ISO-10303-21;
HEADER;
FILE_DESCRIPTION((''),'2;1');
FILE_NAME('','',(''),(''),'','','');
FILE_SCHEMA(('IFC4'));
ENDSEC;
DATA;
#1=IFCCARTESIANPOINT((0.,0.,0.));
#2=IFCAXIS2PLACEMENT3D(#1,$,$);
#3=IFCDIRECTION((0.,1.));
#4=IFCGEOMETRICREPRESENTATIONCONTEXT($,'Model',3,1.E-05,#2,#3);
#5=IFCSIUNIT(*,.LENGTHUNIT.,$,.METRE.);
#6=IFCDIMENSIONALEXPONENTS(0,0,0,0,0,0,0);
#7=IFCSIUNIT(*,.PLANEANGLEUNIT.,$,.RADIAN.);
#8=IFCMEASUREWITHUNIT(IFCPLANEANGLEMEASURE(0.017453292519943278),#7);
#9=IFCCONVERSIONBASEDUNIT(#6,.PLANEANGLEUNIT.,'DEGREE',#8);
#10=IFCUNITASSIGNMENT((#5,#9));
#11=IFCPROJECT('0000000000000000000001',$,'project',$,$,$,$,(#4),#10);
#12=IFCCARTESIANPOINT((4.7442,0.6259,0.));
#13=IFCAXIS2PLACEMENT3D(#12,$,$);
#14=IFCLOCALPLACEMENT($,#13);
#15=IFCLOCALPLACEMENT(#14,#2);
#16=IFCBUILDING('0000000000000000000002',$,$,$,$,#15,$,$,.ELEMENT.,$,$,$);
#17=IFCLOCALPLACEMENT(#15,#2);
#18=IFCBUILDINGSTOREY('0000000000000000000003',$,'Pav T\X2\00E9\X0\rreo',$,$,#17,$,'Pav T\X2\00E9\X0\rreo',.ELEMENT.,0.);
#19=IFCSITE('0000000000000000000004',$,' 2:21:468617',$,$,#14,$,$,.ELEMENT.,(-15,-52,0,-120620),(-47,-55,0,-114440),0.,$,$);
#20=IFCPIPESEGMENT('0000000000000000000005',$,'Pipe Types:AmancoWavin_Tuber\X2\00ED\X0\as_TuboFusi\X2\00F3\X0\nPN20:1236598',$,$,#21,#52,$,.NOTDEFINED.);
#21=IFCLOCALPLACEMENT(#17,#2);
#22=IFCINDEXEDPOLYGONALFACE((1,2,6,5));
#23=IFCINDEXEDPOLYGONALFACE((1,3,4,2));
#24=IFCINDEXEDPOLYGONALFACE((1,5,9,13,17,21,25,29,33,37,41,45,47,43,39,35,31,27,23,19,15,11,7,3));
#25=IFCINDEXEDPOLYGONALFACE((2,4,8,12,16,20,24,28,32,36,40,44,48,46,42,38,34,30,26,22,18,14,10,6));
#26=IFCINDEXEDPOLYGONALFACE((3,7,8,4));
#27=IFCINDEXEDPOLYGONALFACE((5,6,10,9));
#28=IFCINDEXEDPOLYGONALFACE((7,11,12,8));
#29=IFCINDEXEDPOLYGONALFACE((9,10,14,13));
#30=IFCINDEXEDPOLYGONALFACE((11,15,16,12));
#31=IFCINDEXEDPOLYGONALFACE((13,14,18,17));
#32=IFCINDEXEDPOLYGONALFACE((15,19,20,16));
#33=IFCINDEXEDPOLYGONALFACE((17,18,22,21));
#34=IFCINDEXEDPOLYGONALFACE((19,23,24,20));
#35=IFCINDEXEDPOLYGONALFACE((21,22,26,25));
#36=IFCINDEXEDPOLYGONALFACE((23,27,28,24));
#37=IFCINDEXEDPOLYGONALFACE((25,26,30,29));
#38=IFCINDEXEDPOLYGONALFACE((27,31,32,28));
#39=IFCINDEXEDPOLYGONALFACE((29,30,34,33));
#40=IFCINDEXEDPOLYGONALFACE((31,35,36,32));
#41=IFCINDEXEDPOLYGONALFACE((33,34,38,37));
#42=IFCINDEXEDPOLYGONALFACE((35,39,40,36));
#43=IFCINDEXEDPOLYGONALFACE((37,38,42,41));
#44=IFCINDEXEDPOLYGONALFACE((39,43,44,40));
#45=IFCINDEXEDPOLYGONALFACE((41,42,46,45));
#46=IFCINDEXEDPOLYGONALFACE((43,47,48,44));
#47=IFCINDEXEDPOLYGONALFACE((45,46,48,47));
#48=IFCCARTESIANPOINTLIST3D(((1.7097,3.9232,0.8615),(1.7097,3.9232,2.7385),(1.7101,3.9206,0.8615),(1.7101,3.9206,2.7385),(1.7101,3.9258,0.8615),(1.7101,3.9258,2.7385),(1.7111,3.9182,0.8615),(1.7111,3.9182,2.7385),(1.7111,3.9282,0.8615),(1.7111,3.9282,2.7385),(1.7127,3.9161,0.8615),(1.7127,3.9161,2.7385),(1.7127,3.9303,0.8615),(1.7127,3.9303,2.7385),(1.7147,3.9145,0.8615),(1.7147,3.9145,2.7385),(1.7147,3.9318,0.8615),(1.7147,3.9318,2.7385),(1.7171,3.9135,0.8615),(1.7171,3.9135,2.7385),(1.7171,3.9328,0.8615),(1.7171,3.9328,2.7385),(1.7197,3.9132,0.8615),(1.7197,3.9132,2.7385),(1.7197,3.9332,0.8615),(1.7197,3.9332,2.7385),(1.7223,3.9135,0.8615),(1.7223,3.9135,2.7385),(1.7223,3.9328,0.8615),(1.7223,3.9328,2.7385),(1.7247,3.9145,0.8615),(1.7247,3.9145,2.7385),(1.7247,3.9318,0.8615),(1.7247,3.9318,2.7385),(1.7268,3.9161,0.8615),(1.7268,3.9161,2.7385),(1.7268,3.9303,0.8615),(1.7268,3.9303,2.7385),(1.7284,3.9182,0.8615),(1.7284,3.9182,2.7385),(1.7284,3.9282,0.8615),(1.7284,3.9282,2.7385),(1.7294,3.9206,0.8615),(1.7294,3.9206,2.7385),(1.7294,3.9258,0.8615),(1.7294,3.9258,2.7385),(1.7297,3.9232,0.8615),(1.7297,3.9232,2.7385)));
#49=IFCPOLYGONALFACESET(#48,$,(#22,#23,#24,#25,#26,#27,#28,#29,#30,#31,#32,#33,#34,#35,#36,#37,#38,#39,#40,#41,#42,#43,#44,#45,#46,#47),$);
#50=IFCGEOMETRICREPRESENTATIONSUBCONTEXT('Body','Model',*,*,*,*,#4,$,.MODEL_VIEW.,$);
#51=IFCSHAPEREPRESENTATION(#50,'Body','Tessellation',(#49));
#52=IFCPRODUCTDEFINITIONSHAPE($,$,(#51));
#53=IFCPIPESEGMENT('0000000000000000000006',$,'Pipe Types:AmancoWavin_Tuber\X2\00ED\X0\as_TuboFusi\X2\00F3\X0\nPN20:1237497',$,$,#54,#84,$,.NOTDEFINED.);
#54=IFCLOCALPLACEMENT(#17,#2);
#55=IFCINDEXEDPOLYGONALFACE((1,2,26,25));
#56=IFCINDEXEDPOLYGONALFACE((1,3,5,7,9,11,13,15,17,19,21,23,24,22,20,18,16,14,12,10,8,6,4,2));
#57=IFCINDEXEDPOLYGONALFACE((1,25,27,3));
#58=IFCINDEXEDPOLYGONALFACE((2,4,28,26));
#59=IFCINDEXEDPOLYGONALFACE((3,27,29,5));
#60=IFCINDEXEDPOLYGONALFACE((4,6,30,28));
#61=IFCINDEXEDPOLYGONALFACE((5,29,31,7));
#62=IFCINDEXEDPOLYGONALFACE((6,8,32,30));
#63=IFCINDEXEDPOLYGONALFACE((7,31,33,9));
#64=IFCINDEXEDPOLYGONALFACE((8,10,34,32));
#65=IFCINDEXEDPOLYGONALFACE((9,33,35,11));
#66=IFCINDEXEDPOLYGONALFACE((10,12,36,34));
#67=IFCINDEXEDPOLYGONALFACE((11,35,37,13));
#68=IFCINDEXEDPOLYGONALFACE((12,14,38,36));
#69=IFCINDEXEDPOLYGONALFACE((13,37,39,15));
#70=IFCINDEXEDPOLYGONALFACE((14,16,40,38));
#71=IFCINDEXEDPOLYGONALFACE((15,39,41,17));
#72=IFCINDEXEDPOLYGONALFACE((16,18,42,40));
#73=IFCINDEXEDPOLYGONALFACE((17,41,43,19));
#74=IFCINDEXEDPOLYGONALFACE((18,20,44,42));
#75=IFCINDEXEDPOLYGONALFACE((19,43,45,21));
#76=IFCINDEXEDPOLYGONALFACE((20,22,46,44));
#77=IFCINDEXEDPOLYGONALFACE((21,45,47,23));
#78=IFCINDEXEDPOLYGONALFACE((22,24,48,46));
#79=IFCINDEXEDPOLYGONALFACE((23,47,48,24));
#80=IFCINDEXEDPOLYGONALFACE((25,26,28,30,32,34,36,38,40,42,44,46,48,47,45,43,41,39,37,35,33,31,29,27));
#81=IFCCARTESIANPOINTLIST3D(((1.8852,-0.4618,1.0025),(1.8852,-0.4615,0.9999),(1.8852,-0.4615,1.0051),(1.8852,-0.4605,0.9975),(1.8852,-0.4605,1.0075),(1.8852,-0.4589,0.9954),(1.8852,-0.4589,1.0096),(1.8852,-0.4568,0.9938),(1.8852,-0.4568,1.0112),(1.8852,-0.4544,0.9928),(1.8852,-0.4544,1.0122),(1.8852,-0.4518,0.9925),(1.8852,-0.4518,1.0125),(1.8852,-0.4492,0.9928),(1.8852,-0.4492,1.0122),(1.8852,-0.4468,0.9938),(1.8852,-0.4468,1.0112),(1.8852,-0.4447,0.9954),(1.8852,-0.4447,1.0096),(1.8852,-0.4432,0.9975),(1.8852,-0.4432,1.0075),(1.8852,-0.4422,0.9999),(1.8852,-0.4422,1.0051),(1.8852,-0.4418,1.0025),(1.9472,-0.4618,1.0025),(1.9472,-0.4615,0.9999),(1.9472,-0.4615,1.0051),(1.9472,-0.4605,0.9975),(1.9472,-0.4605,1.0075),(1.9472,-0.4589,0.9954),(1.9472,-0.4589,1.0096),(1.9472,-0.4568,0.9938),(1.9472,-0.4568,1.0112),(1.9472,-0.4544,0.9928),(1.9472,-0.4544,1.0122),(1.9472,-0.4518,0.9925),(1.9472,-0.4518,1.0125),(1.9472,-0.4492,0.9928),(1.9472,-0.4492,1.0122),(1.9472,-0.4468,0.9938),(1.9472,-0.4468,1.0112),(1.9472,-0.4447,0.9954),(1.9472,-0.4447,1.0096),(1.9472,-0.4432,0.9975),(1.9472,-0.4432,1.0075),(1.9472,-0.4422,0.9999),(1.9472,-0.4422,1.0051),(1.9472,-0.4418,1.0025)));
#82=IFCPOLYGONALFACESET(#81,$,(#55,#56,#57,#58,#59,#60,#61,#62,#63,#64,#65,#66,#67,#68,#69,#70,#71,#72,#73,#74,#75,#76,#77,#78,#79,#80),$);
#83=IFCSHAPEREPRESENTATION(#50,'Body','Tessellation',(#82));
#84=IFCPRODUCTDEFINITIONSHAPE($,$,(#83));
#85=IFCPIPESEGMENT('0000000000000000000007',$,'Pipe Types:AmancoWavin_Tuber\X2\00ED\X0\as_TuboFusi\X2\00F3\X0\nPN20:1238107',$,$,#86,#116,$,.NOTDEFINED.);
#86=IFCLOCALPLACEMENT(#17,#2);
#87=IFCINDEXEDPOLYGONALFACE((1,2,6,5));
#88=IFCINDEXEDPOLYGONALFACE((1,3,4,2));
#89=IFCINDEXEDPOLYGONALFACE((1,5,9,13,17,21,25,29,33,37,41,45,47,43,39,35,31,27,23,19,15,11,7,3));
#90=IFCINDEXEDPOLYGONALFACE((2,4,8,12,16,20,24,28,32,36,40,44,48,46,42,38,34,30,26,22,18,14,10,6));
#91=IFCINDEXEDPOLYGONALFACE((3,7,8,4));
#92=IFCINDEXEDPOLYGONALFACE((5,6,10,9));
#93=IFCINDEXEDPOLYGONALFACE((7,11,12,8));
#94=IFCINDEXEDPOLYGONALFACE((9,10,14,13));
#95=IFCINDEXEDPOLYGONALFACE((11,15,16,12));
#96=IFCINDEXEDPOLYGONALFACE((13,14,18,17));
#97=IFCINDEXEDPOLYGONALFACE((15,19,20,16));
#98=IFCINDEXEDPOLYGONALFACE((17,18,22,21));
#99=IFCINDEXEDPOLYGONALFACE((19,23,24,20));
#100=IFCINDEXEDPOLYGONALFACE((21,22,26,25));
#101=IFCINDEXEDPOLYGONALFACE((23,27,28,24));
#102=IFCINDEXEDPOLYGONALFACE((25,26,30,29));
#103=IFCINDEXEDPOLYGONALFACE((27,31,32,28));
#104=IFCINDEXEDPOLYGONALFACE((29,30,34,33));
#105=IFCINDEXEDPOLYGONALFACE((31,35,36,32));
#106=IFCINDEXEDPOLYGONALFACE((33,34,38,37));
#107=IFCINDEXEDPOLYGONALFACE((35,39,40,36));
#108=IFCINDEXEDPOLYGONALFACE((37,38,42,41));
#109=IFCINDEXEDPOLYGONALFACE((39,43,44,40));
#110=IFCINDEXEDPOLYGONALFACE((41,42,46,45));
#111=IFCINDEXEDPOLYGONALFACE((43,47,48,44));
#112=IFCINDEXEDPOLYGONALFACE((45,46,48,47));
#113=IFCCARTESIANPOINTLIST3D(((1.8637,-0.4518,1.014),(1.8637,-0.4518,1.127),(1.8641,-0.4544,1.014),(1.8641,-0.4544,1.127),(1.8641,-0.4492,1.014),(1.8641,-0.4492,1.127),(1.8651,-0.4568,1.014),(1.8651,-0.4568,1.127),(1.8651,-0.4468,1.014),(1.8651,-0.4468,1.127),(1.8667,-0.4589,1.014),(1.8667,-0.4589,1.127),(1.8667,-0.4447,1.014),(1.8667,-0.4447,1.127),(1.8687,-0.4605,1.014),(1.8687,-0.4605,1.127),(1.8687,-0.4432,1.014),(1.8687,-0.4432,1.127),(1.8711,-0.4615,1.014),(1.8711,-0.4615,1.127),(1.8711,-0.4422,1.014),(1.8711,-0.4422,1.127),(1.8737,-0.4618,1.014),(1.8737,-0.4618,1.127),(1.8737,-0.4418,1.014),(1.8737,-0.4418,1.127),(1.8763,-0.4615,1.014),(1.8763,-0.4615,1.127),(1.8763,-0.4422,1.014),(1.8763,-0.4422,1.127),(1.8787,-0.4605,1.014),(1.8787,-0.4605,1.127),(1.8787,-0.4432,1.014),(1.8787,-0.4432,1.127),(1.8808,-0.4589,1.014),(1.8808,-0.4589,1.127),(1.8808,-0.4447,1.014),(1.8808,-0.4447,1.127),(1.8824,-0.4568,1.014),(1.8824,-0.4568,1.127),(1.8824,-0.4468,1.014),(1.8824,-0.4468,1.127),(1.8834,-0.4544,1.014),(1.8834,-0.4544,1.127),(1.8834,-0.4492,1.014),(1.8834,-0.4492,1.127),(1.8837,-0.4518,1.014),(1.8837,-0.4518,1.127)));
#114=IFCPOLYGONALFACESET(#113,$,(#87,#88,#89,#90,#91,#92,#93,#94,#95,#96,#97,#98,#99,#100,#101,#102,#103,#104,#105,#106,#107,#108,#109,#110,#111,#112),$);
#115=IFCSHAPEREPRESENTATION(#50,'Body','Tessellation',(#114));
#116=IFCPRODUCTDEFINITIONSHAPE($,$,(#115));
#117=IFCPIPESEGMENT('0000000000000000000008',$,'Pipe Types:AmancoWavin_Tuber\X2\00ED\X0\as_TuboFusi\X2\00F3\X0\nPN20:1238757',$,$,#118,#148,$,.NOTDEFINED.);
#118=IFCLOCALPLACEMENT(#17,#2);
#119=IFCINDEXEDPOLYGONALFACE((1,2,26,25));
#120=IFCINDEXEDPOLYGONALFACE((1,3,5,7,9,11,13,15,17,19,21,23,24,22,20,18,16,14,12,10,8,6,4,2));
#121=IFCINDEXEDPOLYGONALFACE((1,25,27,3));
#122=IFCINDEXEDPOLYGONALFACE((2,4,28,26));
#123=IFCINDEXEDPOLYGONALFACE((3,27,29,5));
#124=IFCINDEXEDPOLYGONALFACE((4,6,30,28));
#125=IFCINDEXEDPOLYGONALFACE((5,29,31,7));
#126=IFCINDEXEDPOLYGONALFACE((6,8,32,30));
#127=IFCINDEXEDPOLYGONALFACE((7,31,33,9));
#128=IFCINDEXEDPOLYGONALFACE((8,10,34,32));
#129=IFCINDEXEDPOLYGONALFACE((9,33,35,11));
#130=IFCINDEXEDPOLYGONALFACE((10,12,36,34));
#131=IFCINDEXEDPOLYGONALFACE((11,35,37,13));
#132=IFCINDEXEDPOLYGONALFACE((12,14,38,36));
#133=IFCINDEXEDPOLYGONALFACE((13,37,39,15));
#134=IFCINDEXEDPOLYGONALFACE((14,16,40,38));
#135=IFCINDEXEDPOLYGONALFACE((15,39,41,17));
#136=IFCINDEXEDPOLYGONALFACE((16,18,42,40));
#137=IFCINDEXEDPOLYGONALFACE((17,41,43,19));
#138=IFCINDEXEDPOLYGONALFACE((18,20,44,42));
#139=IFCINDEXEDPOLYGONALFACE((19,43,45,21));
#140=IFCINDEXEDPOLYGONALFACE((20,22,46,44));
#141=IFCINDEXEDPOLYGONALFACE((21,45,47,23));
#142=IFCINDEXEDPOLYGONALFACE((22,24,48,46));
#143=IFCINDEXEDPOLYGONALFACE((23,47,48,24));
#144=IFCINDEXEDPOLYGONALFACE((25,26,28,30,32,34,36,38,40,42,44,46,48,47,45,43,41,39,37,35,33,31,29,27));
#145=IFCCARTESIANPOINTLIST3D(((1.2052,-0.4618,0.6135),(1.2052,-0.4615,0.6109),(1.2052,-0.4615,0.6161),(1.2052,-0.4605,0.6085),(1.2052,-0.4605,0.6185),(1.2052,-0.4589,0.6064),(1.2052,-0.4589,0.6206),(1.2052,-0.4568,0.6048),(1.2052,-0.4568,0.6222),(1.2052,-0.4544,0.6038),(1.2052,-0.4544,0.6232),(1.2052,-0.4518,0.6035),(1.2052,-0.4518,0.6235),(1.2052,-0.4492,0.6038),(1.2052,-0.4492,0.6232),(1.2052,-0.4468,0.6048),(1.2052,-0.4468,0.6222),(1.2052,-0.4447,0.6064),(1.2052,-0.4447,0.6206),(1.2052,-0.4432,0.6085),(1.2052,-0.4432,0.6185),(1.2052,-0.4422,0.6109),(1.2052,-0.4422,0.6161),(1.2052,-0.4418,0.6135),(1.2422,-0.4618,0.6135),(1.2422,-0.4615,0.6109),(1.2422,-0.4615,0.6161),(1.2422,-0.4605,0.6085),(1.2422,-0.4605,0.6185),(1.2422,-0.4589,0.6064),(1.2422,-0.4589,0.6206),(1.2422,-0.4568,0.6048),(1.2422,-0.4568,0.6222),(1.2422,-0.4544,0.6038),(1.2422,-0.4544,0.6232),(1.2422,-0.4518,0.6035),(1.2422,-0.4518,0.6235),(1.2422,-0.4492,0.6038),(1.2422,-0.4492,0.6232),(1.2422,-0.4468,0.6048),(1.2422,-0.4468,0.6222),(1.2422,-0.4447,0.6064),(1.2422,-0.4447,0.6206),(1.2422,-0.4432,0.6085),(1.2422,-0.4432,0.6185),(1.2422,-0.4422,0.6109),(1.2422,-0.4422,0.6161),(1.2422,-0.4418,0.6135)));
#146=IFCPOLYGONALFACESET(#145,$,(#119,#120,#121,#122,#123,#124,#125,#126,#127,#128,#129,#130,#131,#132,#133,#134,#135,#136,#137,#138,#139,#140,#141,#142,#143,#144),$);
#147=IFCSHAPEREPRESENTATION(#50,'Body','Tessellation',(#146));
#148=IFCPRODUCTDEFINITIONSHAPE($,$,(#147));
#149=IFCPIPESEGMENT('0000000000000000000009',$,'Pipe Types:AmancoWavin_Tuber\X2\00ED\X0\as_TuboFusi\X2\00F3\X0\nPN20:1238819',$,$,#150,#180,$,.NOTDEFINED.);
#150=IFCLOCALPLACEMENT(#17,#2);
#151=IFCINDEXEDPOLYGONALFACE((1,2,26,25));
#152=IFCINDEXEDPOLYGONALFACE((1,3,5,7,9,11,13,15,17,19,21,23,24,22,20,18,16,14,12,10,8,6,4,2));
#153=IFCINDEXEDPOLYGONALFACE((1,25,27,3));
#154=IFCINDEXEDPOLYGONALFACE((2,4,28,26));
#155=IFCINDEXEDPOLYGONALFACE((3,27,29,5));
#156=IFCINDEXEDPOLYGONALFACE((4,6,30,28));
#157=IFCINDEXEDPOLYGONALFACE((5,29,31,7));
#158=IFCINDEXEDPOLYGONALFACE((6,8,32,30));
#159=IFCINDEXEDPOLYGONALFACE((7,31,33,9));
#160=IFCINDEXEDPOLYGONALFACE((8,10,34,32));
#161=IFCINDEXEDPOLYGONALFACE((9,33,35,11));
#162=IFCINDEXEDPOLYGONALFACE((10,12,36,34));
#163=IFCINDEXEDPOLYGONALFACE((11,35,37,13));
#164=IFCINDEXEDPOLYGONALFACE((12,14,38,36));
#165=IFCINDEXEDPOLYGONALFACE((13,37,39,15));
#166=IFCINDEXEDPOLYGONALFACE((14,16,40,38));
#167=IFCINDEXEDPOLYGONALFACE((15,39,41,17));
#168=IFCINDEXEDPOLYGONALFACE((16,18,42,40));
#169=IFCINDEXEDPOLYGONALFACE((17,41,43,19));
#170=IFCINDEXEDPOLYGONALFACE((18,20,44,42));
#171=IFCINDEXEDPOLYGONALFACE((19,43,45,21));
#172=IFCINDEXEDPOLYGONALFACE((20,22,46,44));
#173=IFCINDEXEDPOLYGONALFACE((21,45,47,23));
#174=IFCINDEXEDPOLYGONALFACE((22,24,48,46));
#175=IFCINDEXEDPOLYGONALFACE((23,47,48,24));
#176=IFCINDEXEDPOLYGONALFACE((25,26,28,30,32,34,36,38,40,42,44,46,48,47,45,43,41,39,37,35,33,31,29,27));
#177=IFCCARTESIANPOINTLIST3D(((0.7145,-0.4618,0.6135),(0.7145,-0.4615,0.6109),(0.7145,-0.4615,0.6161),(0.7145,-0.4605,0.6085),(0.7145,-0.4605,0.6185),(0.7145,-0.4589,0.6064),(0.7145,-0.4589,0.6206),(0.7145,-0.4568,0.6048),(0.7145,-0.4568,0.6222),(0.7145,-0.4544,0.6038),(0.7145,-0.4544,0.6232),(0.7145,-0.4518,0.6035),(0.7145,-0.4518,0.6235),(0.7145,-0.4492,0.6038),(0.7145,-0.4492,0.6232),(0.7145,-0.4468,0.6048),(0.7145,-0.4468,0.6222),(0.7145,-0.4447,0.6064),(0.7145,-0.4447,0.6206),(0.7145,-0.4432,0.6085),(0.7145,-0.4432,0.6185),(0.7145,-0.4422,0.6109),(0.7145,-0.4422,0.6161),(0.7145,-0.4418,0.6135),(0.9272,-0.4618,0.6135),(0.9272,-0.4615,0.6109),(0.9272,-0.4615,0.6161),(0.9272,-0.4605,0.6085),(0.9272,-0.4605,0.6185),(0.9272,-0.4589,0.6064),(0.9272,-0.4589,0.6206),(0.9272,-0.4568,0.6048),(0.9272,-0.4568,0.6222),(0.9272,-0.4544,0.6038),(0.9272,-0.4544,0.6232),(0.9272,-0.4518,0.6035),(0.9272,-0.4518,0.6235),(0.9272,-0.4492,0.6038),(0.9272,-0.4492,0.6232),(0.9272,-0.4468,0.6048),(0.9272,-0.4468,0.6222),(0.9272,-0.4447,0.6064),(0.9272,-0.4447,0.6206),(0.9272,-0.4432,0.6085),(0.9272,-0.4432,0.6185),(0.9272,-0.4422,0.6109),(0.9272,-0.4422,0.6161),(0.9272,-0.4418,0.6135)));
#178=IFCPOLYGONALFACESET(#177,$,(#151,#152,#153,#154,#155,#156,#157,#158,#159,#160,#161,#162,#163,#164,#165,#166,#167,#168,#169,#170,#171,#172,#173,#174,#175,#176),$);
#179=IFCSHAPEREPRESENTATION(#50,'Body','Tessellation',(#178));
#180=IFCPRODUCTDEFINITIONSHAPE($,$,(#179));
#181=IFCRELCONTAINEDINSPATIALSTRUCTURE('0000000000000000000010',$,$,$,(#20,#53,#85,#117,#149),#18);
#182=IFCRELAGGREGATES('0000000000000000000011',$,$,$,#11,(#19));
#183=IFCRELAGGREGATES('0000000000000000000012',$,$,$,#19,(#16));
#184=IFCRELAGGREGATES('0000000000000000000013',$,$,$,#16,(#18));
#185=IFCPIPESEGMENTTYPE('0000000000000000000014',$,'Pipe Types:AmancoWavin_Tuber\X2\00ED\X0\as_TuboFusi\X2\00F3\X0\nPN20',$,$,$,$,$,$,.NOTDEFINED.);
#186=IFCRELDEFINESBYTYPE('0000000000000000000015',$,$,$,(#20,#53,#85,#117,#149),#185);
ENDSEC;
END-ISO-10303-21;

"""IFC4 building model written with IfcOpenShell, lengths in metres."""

from ifc_helpers import new_model, entity, si_unit, converted_unit, direction, frame, origin, place, context, subcontext, project, spatial, arc, indexed_curve, outline, extrude, type_object, element, save


model = new_model("IFC4")

# Units and contexts
model_context = context("Model", 3, precision=1e-05, world=origin(), true_north=direction((0.0, 1.0)))
body_context = subcontext(model_context, "Body", "Model", "MODEL_VIEW")
ifc_project = project(units=[si_unit("LENGTHUNIT", "METRE"), converted_unit("PLANEANGLEUNIT", "DEGREE", entity("IfcPlaneAngleMeasure", 0.017453292519943278), si_unit("PLANEANGLEUNIT", "RADIAN"), dimensions=[0, 0, 0, 0, 0, 0, 0])], contexts=[model_context])

# Site, building, storey
site_placement = place(None, frame((4.7442, 0.6259, 0.0)))
site = spatial("IfcSite", under=ifc_project, at=site_placement, Name=" 2:21:468617", CompositionType="ELEMENT", RefLatitude=(-15, -52, 0, -120620), RefLongitude=(-47, -55, 0, -114440), RefElevation=0.0)
building_placement = place(site_placement, origin())
building = spatial("IfcBuilding", under=site, at=building_placement, CompositionType="ELEMENT")
storey_placement = place(building_placement, origin())
storey = spatial("IfcBuildingStorey", under=building, at=storey_placement, Name="Pav Térreo", LongName="Pav Térreo", CompositionType="ELEMENT", Elevation=0.0)

# Pipe segments
pipe_segment_type_1 = type_object("IfcPipeSegmentType", Name="Pipe Types:AmancoWavin_Tuberías_TuboFusiónPN20", PredefinedType="NOTDEFINED")
pipe_segment_1_placement = place(storey_placement, origin())
element("IfcPipeSegment", 1, at=pipe_segment_1_placement, inside=storey, type_object=pipe_segment_type_1, Name="Pipe Types:AmancoWavin_Tuberías_TuboFusiónPN20:1236598", PredefinedType="NOTDEFINED", context=body_context, shape_type="SweptSolid", body=[
    extrude(outline(indexed_curve([(0.01, 0.0), (0.0071, 0.0071), (0.0, 0.01), (-0.0071, 0.0071), (-0.01, 0.0), (-0.0071, -0.0071), (0.0, -0.01), (0.0071, -0.0071)], segments=[arc(1, 2, 3), arc(3, 4, 5), arc(5, 6, 7), arc(7, 8, 1)], self_intersect=False)), frame((1.7197, 3.9232, 0.8615)), (0.0, 0.0, 1.0), 1.877),
])
pipe_segment_2_placement = place(storey_placement, origin())
element("IfcPipeSegment", 2, at=pipe_segment_2_placement, inside=storey, type_object=pipe_segment_type_1, Name="Pipe Types:AmancoWavin_Tuberías_TuboFusiónPN20:1237497", PredefinedType="NOTDEFINED", context=body_context, shape_type="SweptSolid", body=[
    extrude(outline(indexed_curve([(0.01, 0.0), (0.0071, 0.0071), (0.0, 0.01), (-0.0071, 0.0071), (-0.01, 0.0), (-0.0071, -0.0071), (0.0, -0.01), (0.0071, -0.0071)], segments=[arc(1, 2, 3), arc(3, 4, 5), arc(5, 6, 7), arc(7, 8, 1)], self_intersect=False)), frame((1.8852, -0.4518, 1.0025), z_axis=(1.0, 0.0, 0.0), x_axis=(0.0, 1.0, 0.0)), (0.0, 0.0, 1.0), 0.062),
])
pipe_segment_3_placement = place(storey_placement, origin())
element("IfcPipeSegment", 3, at=pipe_segment_3_placement, inside=storey, type_object=pipe_segment_type_1, Name="Pipe Types:AmancoWavin_Tuberías_TuboFusiónPN20:1238107", PredefinedType="NOTDEFINED", context=body_context, shape_type="SweptSolid", body=[
    extrude(outline(indexed_curve([(0.01, 0.0), (0.0071, 0.0071), (0.0, 0.01), (-0.0071, 0.0071), (-0.01, 0.0), (-0.0071, -0.0071), (0.0, -0.01), (0.0071, -0.0071)], segments=[arc(1, 2, 3), arc(3, 4, 5), arc(5, 6, 7), arc(7, 8, 1)], self_intersect=False)), frame((1.8737, -0.4518, 1.014), z_axis=(0.0, 0.0, 1.0), x_axis=(-1.0, 0.0, 0.0)), (0.0, 0.0, 1.0), 0.113),
])
pipe_segment_4_placement = place(storey_placement, origin())
element("IfcPipeSegment", 4, at=pipe_segment_4_placement, inside=storey, type_object=pipe_segment_type_1, Name="Pipe Types:AmancoWavin_Tuberías_TuboFusiónPN20:1238757", PredefinedType="NOTDEFINED", context=body_context, shape_type="SweptSolid", body=[
    extrude(outline(indexed_curve([(0.01, 0.0), (0.0071, 0.0071), (0.0, 0.01), (-0.0071, 0.0071), (-0.01, 0.0), (-0.0071, -0.0071), (0.0, -0.01), (0.0071, -0.0071)], segments=[arc(1, 2, 3), arc(3, 4, 5), arc(5, 6, 7), arc(7, 8, 1)], self_intersect=False)), frame((1.2052, -0.4518, 0.6135), z_axis=(1.0, 0.0, 0.0), x_axis=(0.0, 1.0, 0.0)), (0.0, 0.0, 1.0), 0.037),
])
pipe_segment_5_placement = place(storey_placement, origin())
element("IfcPipeSegment", 5, at=pipe_segment_5_placement, inside=storey, type_object=pipe_segment_type_1, Name="Pipe Types:AmancoWavin_Tuberías_TuboFusiónPN20:1238819", PredefinedType="NOTDEFINED", context=body_context, shape_type="SweptSolid", body=[
    extrude(outline(indexed_curve([(0.01, 0.0), (0.0071, 0.0071), (0.0, 0.01), (-0.0071, 0.0071), (-0.01, 0.0), (-0.0071, -0.0071), (0.0, -0.01), (0.0071, -0.0071)], segments=[arc(1, 2, 3), arc(3, 4, 5), arc(5, 6, 7), arc(7, 8, 1)], self_intersect=False)), frame((0.7145, -0.4518, 0.6135), z_axis=(1.0, 0.0, 0.0), x_axis=(0.0, 1.0, 0.0)), (0.0, 0.0, 1.0), 0.2127),
])

save(model, "model.ifc")
